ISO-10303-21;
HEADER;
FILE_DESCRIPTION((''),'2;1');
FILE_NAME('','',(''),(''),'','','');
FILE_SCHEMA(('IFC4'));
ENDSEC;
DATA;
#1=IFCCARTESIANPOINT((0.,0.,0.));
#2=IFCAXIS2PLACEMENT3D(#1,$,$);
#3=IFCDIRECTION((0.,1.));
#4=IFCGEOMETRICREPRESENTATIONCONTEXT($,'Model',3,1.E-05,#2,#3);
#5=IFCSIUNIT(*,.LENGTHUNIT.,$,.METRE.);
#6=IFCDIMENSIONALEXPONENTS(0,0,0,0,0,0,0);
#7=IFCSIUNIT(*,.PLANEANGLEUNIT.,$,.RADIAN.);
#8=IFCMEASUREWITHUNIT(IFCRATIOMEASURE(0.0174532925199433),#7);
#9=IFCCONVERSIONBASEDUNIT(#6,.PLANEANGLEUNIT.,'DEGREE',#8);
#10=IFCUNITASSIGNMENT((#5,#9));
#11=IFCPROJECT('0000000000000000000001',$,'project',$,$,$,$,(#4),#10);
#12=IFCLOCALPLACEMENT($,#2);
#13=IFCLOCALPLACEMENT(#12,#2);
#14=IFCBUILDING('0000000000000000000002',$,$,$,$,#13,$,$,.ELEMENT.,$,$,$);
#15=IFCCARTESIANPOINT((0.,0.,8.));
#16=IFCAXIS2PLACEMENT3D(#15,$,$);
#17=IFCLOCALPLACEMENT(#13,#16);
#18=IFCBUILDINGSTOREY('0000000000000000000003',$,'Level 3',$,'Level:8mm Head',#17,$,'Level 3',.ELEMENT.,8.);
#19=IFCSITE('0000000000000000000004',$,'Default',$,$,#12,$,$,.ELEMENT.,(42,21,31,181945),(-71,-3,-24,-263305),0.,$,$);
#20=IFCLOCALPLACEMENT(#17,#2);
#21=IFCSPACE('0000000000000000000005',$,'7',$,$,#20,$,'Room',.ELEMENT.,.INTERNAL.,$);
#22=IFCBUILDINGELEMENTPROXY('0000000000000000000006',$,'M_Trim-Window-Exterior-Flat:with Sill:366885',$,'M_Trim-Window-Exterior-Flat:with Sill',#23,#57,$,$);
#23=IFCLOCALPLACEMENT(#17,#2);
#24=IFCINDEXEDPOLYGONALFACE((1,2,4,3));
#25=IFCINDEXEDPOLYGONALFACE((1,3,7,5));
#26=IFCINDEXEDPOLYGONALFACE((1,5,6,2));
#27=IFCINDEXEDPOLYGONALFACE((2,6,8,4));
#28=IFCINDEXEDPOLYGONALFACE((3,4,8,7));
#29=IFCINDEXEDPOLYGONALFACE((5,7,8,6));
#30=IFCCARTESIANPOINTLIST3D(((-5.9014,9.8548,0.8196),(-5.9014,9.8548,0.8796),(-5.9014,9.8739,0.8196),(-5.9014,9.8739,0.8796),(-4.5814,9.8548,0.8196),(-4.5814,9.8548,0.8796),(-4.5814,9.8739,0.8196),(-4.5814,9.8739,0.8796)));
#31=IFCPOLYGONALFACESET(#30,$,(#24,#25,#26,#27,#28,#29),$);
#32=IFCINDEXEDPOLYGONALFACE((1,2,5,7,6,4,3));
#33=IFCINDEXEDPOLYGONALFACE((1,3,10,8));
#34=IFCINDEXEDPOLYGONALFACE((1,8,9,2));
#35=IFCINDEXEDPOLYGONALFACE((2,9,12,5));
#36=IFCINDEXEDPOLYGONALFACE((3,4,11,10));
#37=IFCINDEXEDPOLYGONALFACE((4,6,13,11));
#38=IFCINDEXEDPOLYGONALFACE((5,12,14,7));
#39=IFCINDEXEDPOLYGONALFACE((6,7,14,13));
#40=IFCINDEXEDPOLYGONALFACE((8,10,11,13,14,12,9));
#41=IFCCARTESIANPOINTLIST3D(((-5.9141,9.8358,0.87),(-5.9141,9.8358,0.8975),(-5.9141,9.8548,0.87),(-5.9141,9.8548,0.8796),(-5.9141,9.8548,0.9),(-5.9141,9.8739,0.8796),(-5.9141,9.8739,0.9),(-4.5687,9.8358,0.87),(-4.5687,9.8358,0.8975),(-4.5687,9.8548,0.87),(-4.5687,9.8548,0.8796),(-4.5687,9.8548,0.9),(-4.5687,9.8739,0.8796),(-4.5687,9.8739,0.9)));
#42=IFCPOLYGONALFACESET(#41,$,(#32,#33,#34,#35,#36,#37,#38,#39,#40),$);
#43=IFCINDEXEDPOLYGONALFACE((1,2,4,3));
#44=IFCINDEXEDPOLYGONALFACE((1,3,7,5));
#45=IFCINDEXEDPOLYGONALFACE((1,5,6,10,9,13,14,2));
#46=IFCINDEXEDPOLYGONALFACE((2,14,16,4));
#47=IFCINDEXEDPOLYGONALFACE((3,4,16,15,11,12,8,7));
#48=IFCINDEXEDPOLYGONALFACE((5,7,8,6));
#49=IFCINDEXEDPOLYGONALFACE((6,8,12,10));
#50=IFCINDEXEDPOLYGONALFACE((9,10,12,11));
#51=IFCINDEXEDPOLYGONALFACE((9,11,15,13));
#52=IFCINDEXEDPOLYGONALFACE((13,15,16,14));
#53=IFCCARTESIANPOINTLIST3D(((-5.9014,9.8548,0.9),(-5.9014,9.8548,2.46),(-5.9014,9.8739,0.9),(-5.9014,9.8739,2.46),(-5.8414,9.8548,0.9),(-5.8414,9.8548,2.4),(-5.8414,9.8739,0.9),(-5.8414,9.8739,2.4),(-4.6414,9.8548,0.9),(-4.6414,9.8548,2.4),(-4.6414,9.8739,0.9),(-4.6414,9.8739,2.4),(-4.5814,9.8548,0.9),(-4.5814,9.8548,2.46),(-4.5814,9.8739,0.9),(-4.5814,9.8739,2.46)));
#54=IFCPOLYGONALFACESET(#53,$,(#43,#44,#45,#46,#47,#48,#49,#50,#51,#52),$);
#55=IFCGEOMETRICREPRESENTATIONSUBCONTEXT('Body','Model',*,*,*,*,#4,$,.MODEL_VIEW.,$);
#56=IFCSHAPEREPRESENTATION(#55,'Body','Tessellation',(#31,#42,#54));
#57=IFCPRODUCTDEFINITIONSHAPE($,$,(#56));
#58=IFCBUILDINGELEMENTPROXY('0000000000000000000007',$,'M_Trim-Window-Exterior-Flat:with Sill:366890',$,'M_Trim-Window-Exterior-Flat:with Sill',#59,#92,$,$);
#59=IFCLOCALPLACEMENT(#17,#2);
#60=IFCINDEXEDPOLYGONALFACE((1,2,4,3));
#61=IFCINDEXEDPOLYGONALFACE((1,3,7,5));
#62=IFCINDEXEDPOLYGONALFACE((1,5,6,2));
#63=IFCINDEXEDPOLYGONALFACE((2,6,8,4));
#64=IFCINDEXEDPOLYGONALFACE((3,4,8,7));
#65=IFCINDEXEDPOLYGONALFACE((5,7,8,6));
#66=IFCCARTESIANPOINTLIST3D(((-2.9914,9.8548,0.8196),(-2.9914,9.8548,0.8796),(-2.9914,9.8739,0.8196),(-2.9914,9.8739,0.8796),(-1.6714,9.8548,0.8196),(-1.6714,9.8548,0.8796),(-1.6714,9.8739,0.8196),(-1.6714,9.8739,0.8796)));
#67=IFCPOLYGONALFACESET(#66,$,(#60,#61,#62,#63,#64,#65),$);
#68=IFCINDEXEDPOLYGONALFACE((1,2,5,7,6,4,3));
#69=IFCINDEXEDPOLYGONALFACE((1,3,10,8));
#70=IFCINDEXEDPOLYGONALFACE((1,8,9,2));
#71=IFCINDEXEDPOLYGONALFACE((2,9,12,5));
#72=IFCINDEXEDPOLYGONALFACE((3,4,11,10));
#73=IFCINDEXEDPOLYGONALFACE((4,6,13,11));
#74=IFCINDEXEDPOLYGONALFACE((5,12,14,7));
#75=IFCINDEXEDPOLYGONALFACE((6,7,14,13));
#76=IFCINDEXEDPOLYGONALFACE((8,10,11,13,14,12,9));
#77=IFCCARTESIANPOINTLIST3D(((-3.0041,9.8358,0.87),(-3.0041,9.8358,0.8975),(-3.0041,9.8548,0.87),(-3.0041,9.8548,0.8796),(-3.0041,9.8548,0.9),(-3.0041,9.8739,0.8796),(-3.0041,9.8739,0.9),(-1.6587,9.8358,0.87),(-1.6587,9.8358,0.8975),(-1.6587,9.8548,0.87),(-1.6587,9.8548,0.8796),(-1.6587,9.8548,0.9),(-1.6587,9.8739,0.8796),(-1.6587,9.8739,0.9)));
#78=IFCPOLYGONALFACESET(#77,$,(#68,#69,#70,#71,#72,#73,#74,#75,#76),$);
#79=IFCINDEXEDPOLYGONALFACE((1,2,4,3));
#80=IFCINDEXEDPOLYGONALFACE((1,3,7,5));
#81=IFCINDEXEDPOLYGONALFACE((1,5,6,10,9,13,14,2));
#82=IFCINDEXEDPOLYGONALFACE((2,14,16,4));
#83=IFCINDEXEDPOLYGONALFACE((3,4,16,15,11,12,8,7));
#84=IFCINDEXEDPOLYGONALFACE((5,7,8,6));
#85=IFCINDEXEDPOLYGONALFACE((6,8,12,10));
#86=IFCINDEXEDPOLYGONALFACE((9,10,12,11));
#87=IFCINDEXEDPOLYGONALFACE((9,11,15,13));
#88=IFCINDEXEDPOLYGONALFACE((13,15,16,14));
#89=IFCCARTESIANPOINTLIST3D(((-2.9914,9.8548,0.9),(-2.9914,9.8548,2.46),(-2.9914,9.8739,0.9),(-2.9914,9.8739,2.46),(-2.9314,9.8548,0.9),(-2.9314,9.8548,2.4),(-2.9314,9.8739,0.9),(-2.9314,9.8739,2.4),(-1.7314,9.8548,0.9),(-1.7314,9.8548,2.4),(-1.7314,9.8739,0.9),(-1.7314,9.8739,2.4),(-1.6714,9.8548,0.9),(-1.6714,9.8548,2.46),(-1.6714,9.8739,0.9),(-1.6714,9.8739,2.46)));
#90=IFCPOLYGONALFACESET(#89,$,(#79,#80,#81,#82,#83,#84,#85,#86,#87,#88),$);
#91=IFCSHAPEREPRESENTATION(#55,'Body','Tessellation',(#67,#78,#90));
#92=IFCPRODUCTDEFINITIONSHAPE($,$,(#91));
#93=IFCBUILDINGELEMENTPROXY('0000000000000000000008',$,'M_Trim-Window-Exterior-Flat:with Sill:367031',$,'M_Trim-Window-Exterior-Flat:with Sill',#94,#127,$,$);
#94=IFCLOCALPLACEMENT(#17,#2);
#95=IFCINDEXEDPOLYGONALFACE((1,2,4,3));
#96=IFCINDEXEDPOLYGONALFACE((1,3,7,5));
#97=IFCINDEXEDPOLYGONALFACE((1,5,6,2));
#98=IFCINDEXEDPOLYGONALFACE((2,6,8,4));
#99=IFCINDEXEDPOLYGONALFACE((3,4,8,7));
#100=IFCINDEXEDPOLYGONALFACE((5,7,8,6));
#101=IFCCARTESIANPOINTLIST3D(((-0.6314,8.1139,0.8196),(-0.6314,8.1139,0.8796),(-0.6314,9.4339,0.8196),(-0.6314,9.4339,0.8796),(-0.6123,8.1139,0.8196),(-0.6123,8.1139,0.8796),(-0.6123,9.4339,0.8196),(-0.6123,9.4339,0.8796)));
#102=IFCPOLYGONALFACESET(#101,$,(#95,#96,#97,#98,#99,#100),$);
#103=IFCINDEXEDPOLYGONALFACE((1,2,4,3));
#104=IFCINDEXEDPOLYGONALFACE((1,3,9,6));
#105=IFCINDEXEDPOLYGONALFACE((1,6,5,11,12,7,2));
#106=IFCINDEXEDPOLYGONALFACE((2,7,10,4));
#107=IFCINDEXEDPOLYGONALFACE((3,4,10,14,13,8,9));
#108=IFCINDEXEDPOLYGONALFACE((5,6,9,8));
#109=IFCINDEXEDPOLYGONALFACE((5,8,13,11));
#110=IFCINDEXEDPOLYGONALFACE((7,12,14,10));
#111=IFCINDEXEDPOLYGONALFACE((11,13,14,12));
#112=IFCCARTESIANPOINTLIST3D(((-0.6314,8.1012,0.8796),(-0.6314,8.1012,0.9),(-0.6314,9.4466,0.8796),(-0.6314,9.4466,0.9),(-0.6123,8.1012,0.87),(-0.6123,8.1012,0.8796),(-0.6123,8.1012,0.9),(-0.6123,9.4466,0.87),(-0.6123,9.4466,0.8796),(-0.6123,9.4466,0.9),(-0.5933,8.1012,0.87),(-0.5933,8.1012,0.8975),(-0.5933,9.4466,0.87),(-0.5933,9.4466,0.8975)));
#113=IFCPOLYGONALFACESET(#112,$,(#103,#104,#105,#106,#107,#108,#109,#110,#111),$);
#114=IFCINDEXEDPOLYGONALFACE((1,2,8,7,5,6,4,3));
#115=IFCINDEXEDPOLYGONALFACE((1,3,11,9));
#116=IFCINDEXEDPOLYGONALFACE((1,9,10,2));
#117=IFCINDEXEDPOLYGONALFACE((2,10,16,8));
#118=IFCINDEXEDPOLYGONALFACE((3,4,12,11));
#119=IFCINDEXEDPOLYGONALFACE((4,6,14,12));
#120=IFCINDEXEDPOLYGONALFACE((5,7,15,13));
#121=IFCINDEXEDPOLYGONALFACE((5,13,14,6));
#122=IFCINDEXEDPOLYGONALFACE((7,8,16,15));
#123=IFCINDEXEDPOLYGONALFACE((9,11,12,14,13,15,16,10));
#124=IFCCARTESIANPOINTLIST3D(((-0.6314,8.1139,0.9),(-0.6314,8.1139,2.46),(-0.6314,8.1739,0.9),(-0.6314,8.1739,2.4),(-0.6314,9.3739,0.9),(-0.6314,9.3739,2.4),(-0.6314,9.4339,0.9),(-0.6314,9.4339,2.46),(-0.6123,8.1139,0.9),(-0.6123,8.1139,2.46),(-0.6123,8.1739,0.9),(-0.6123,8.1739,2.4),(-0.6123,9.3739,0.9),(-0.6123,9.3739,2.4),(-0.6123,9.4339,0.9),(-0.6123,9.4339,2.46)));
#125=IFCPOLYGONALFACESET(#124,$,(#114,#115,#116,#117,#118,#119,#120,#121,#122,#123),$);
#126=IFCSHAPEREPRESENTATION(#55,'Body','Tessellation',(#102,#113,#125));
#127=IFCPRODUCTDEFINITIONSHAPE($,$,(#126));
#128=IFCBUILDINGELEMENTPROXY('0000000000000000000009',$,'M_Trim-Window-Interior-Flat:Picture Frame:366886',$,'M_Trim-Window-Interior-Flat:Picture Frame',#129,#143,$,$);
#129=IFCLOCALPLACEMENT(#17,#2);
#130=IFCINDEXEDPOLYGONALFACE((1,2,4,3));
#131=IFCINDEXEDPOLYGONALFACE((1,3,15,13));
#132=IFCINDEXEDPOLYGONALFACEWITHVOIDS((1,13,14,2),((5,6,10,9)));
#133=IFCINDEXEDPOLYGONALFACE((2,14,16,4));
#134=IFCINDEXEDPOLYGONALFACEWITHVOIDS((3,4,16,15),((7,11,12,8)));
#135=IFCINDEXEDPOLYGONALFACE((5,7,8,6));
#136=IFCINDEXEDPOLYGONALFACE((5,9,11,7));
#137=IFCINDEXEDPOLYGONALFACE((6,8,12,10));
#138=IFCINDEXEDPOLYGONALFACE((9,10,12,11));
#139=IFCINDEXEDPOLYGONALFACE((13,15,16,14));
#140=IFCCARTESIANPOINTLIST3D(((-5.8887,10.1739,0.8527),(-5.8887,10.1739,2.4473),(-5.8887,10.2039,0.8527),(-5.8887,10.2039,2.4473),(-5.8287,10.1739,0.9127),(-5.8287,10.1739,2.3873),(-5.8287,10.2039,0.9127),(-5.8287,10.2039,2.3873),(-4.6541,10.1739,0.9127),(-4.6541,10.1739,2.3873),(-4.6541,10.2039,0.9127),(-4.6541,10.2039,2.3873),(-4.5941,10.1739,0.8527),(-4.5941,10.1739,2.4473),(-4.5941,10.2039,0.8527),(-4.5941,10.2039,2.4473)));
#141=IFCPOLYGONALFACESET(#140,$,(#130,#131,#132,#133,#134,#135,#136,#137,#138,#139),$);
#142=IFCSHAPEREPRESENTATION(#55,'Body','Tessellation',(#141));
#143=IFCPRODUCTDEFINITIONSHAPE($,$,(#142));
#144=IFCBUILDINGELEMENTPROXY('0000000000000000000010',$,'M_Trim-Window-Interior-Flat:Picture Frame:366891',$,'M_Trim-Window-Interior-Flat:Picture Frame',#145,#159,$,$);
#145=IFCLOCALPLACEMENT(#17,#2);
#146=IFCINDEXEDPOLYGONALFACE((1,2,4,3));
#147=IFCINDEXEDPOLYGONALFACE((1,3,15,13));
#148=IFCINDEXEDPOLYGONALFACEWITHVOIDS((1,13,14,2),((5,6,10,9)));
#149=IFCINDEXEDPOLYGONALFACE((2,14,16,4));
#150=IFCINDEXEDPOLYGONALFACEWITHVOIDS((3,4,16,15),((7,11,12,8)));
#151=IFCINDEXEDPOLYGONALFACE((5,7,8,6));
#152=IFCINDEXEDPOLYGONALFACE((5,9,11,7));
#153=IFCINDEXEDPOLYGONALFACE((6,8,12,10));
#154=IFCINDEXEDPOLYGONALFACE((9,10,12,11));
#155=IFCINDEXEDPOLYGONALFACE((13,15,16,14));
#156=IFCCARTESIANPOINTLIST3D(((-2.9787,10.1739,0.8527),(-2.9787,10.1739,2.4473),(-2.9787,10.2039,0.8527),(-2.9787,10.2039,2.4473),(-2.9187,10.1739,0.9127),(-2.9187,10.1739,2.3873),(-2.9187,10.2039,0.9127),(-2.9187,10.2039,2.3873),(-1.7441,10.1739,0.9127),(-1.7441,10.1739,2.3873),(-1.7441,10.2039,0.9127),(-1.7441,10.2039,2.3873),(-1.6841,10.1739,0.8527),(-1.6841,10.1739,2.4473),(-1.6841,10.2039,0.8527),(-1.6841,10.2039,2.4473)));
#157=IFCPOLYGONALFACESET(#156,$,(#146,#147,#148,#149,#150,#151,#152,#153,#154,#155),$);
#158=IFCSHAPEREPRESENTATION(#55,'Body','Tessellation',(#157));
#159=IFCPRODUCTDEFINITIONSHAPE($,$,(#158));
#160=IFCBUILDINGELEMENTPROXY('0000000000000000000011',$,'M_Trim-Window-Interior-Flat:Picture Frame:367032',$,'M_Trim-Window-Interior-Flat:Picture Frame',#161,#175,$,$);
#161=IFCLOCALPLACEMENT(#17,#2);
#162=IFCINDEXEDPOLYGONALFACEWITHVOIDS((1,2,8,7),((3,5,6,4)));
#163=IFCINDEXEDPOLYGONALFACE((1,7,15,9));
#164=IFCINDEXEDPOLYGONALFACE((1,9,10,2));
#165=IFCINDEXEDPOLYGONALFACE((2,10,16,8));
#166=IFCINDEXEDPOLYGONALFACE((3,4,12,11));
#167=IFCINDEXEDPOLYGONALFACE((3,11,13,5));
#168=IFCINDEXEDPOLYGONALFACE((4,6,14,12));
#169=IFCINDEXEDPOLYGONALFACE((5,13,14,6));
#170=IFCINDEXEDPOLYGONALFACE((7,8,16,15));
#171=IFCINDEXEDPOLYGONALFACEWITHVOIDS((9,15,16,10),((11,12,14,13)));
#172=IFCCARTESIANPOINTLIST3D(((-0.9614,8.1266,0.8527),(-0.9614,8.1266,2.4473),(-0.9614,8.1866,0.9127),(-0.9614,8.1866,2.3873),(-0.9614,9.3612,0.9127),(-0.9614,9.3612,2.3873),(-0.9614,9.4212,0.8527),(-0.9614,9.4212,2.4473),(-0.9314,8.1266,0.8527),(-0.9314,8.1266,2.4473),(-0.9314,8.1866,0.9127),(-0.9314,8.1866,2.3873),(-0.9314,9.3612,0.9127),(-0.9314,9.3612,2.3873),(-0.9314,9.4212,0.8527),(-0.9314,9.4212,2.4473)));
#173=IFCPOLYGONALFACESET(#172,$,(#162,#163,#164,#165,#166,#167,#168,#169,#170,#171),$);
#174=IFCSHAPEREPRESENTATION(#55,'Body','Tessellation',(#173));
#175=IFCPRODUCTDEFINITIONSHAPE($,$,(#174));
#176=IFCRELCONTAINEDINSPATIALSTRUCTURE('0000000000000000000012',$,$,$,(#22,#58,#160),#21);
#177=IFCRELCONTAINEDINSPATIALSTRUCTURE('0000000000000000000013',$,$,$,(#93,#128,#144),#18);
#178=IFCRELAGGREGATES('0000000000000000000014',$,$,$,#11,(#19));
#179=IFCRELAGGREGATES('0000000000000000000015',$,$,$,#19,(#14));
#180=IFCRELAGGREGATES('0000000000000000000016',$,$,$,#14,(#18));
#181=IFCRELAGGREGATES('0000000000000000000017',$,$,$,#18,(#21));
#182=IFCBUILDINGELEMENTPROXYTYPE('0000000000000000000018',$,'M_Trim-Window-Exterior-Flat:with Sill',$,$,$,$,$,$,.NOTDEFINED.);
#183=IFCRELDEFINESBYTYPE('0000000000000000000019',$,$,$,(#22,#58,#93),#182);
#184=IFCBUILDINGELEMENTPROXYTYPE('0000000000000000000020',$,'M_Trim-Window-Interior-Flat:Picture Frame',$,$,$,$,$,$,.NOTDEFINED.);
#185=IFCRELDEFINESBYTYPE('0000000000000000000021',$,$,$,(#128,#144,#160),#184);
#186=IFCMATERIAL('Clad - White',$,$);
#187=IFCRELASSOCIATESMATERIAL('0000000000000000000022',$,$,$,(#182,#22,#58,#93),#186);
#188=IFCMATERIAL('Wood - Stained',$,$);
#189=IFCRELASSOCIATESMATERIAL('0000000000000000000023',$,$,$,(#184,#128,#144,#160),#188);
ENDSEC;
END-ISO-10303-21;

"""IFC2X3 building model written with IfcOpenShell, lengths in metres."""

from ifc_helpers import new_model, entity, si_unit, converted_unit, direction, frame, frame_2d, origin, place, context, subcontext, project, spatial, polyline, rectangle, outline, extrude, source, transform, mapped, material, type_object, type_shapes, element, save


model = new_model("IFC2X3")

# Units and contexts
model_context = context("Model", 3, precision=1e-05, world=origin(), true_north=direction((0.0, 1.0)))
body_context = subcontext(model_context, "Body", "Model", "MODEL_VIEW")
ifc_project = project(units=[si_unit("LENGTHUNIT", "METRE"), converted_unit("PLANEANGLEUNIT", "DEGREE", entity("IfcRatioMeasure", 0.0174532925199433), si_unit("PLANEANGLEUNIT", "RADIAN"), dimensions=[0, 0, 0, 0, 0, 0, 0])], contexts=[model_context])

# Site, building, storey
site_placement = place(None, origin())
site = spatial("IfcSite", under=ifc_project, at=site_placement, Name="Default", CompositionType="ELEMENT", RefLatitude=(42, 21, 31, 181945), RefLongitude=(-71, -3, -24, -263305), RefElevation=0.0)
building_placement = place(site_placement, origin())
building = spatial("IfcBuilding", under=site, at=building_placement, CompositionType="ELEMENT")
storey_placement = place(building_placement, frame((0.0, 0.0, 8.0)))
storey = spatial("IfcBuildingStorey", under=building, at=storey_placement, Name="Level 3", ObjectType="Level:8mm Head", LongName="Level 3", CompositionType="ELEMENT", Elevation=8.0)

# Shared definitions
ifc_material_1 = material(Name="Clad - White")
ifc_material_2 = material(Name="Wood - Stained")

# Shared definitions
space_placement = place(storey_placement, origin())
space = spatial("IfcSpace", under=storey, at=space_placement, Name="7", LongName="Room", CompositionType="ELEMENT", InteriorOrExteriorSpace="INTERNAL")

# Building element proxies
building_element_proxy_type_1 = type_object("IfcBuildingElementProxyType", Name="M_Trim-Window-Exterior-Flat:with Sill", PredefinedType="NOTDEFINED", material=ifc_material_1)
shared_shape_1 = source(origin(), body_context, "Body", "SweptSolid", [
    extrude(rectangle(XDim=1.32, YDim=0.06, at=frame_2d((0.0, 0.0), x_axis=(1.0, 0.0))), frame((0.0, -1.5504, 0.0), z_axis=(0.0, 0.0, 1.0), x_axis=(-1.0, 0.0, 0.0)), (0.0, 0.0, 1.0), 0.0191),
    extrude(outline(polyline([(-0.019, -0.0152), (0.0, -0.0152), (0.0, -0.0057), (0.019, -0.0057), (0.019, 0.0148), (0.0, 0.0148), (-0.019, 0.0123), (-0.019, -0.0152)])), frame((-0.6727, -1.5148, 0.019), z_axis=(1.0, 0.0, 0.0), x_axis=(0.0, 0.0, -1.0)), (0.0, 0.0, 1.0), 1.3454),
    extrude(outline(polyline([(-0.795, -0.66), (0.765, -0.66), (0.765, -0.6), (-0.735, -0.6), (-0.735, 0.6), (0.765, 0.6), (0.765, 0.66), (-0.795, 0.66), (-0.795, -0.66)])), frame((0.0, -0.735, 0.0), z_axis=(0.0, 0.0, 1.0), x_axis=(0.0, -1.0, 0.0)), (0.0, 0.0, 1.0), 0.0191),
])
type_shapes(building_element_proxy_type_1, [shared_shape_1])
for number, where, z_axis, x_axis, name in (
    (1, (-5.2414, 9.8739, 2.4), (0.0, -1.0, 0.0), (1.0, 0.0, 0.0), "M_Trim-Window-Exterior-Flat:with Sill:366885"),
    (2, (-2.3314, 9.8739, 2.4), (0.0, -1.0, 0.0), (1.0, 0.0, 0.0), "M_Trim-Window-Exterior-Flat:with Sill:366890"),
):
    element("IfcBuildingElementProxy", number, at=place(space_placement, frame(where, z_axis=z_axis, x_axis=x_axis)), inside=space, type_object=building_element_proxy_type_1, material=ifc_material_1, Name=name, ObjectType="M_Trim-Window-Exterior-Flat:with Sill", context=body_context, shape_type="MappedRepresentation", body=[
        mapped(shared_shape_1, transform((0.0, 0.0, 0.0), scale=1.0)),
    ])
proxy_1_placement = place(storey_placement, frame((-0.6314, 8.7739, 2.4), z_axis=(1.0, 0.0, 0.0), x_axis=(0.0, 1.0, 0.0)))
element("IfcBuildingElementProxy", 3, at=proxy_1_placement, inside=storey, type_object=building_element_proxy_type_1, material=ifc_material_1, Name="M_Trim-Window-Exterior-Flat:with Sill:367031", ObjectType="M_Trim-Window-Exterior-Flat:with Sill", context=body_context, shape_type="MappedRepresentation", body=[
    mapped(shared_shape_1, transform((0.0, 0.0, 0.0), scale=1.0)),
])
building_element_proxy_type_2 = type_object("IfcBuildingElementProxyType", Name="M_Trim-Window-Interior-Flat:Picture Frame", PredefinedType="NOTDEFINED", material=ifc_material_2)
shared_shape_2 = source(origin(), body_context, "Body", "SweptSolid", [
    extrude(outline(polyline([(-0.6473, -0.7973), (0.6473, -0.7973), (0.6473, 0.7973), (-0.6473, 0.7973), (-0.6473, -0.7973)]), holes=[polyline([(-0.5873, -0.7373), (-0.5873, 0.7373), (0.5873, 0.7373), (0.5873, -0.7373), (-0.5873, -0.7373)])]), frame((0.0, -0.75, 0.0), z_axis=(0.0, 0.0, 1.0), x_axis=(-1.0, 0.0, 0.0)), (0.0, 0.0, 1.0), 0.03),
])
type_shapes(building_element_proxy_type_2, [shared_shape_2])
for number, where, z_axis, x_axis, name in (
    (4, (-5.2414, 10.1739, 2.4), (0.0, 1.0, 0.0), (-1.0, 0.0, 0.0), "M_Trim-Window-Interior-Flat:Picture Frame:366886"),
    (5, (-2.3314, 10.1739, 2.4), (0.0, 1.0, 0.0), (-1.0, 0.0, 0.0), "M_Trim-Window-Interior-Flat:Picture Frame:366891"),
):
    element("IfcBuildingElementProxy", number, at=place(storey_placement, frame(where, z_axis=z_axis, x_axis=x_axis)), inside=storey, type_object=building_element_proxy_type_2, material=ifc_material_2, Name=name, ObjectType="M_Trim-Window-Interior-Flat:Picture Frame", context=body_context, shape_type="MappedRepresentation", body=[
        mapped(shared_shape_2, transform((0.0, 0.0, 0.0), scale=1.0)),
    ])
proxy_2_placement = place(space_placement, frame((-0.9314, 8.7739, 2.4), z_axis=(-1.0, 0.0, 0.0), x_axis=(0.0, -1.0, 0.0)))
element("IfcBuildingElementProxy", 6, at=proxy_2_placement, inside=space, type_object=building_element_proxy_type_2, material=ifc_material_2, Name="M_Trim-Window-Interior-Flat:Picture Frame:367032", ObjectType="M_Trim-Window-Interior-Flat:Picture Frame", context=body_context, shape_type="MappedRepresentation", body=[
    mapped(shared_shape_2, transform((0.0, 0.0, 0.0), scale=1.0)),
])

save(model, "model.ifc")
